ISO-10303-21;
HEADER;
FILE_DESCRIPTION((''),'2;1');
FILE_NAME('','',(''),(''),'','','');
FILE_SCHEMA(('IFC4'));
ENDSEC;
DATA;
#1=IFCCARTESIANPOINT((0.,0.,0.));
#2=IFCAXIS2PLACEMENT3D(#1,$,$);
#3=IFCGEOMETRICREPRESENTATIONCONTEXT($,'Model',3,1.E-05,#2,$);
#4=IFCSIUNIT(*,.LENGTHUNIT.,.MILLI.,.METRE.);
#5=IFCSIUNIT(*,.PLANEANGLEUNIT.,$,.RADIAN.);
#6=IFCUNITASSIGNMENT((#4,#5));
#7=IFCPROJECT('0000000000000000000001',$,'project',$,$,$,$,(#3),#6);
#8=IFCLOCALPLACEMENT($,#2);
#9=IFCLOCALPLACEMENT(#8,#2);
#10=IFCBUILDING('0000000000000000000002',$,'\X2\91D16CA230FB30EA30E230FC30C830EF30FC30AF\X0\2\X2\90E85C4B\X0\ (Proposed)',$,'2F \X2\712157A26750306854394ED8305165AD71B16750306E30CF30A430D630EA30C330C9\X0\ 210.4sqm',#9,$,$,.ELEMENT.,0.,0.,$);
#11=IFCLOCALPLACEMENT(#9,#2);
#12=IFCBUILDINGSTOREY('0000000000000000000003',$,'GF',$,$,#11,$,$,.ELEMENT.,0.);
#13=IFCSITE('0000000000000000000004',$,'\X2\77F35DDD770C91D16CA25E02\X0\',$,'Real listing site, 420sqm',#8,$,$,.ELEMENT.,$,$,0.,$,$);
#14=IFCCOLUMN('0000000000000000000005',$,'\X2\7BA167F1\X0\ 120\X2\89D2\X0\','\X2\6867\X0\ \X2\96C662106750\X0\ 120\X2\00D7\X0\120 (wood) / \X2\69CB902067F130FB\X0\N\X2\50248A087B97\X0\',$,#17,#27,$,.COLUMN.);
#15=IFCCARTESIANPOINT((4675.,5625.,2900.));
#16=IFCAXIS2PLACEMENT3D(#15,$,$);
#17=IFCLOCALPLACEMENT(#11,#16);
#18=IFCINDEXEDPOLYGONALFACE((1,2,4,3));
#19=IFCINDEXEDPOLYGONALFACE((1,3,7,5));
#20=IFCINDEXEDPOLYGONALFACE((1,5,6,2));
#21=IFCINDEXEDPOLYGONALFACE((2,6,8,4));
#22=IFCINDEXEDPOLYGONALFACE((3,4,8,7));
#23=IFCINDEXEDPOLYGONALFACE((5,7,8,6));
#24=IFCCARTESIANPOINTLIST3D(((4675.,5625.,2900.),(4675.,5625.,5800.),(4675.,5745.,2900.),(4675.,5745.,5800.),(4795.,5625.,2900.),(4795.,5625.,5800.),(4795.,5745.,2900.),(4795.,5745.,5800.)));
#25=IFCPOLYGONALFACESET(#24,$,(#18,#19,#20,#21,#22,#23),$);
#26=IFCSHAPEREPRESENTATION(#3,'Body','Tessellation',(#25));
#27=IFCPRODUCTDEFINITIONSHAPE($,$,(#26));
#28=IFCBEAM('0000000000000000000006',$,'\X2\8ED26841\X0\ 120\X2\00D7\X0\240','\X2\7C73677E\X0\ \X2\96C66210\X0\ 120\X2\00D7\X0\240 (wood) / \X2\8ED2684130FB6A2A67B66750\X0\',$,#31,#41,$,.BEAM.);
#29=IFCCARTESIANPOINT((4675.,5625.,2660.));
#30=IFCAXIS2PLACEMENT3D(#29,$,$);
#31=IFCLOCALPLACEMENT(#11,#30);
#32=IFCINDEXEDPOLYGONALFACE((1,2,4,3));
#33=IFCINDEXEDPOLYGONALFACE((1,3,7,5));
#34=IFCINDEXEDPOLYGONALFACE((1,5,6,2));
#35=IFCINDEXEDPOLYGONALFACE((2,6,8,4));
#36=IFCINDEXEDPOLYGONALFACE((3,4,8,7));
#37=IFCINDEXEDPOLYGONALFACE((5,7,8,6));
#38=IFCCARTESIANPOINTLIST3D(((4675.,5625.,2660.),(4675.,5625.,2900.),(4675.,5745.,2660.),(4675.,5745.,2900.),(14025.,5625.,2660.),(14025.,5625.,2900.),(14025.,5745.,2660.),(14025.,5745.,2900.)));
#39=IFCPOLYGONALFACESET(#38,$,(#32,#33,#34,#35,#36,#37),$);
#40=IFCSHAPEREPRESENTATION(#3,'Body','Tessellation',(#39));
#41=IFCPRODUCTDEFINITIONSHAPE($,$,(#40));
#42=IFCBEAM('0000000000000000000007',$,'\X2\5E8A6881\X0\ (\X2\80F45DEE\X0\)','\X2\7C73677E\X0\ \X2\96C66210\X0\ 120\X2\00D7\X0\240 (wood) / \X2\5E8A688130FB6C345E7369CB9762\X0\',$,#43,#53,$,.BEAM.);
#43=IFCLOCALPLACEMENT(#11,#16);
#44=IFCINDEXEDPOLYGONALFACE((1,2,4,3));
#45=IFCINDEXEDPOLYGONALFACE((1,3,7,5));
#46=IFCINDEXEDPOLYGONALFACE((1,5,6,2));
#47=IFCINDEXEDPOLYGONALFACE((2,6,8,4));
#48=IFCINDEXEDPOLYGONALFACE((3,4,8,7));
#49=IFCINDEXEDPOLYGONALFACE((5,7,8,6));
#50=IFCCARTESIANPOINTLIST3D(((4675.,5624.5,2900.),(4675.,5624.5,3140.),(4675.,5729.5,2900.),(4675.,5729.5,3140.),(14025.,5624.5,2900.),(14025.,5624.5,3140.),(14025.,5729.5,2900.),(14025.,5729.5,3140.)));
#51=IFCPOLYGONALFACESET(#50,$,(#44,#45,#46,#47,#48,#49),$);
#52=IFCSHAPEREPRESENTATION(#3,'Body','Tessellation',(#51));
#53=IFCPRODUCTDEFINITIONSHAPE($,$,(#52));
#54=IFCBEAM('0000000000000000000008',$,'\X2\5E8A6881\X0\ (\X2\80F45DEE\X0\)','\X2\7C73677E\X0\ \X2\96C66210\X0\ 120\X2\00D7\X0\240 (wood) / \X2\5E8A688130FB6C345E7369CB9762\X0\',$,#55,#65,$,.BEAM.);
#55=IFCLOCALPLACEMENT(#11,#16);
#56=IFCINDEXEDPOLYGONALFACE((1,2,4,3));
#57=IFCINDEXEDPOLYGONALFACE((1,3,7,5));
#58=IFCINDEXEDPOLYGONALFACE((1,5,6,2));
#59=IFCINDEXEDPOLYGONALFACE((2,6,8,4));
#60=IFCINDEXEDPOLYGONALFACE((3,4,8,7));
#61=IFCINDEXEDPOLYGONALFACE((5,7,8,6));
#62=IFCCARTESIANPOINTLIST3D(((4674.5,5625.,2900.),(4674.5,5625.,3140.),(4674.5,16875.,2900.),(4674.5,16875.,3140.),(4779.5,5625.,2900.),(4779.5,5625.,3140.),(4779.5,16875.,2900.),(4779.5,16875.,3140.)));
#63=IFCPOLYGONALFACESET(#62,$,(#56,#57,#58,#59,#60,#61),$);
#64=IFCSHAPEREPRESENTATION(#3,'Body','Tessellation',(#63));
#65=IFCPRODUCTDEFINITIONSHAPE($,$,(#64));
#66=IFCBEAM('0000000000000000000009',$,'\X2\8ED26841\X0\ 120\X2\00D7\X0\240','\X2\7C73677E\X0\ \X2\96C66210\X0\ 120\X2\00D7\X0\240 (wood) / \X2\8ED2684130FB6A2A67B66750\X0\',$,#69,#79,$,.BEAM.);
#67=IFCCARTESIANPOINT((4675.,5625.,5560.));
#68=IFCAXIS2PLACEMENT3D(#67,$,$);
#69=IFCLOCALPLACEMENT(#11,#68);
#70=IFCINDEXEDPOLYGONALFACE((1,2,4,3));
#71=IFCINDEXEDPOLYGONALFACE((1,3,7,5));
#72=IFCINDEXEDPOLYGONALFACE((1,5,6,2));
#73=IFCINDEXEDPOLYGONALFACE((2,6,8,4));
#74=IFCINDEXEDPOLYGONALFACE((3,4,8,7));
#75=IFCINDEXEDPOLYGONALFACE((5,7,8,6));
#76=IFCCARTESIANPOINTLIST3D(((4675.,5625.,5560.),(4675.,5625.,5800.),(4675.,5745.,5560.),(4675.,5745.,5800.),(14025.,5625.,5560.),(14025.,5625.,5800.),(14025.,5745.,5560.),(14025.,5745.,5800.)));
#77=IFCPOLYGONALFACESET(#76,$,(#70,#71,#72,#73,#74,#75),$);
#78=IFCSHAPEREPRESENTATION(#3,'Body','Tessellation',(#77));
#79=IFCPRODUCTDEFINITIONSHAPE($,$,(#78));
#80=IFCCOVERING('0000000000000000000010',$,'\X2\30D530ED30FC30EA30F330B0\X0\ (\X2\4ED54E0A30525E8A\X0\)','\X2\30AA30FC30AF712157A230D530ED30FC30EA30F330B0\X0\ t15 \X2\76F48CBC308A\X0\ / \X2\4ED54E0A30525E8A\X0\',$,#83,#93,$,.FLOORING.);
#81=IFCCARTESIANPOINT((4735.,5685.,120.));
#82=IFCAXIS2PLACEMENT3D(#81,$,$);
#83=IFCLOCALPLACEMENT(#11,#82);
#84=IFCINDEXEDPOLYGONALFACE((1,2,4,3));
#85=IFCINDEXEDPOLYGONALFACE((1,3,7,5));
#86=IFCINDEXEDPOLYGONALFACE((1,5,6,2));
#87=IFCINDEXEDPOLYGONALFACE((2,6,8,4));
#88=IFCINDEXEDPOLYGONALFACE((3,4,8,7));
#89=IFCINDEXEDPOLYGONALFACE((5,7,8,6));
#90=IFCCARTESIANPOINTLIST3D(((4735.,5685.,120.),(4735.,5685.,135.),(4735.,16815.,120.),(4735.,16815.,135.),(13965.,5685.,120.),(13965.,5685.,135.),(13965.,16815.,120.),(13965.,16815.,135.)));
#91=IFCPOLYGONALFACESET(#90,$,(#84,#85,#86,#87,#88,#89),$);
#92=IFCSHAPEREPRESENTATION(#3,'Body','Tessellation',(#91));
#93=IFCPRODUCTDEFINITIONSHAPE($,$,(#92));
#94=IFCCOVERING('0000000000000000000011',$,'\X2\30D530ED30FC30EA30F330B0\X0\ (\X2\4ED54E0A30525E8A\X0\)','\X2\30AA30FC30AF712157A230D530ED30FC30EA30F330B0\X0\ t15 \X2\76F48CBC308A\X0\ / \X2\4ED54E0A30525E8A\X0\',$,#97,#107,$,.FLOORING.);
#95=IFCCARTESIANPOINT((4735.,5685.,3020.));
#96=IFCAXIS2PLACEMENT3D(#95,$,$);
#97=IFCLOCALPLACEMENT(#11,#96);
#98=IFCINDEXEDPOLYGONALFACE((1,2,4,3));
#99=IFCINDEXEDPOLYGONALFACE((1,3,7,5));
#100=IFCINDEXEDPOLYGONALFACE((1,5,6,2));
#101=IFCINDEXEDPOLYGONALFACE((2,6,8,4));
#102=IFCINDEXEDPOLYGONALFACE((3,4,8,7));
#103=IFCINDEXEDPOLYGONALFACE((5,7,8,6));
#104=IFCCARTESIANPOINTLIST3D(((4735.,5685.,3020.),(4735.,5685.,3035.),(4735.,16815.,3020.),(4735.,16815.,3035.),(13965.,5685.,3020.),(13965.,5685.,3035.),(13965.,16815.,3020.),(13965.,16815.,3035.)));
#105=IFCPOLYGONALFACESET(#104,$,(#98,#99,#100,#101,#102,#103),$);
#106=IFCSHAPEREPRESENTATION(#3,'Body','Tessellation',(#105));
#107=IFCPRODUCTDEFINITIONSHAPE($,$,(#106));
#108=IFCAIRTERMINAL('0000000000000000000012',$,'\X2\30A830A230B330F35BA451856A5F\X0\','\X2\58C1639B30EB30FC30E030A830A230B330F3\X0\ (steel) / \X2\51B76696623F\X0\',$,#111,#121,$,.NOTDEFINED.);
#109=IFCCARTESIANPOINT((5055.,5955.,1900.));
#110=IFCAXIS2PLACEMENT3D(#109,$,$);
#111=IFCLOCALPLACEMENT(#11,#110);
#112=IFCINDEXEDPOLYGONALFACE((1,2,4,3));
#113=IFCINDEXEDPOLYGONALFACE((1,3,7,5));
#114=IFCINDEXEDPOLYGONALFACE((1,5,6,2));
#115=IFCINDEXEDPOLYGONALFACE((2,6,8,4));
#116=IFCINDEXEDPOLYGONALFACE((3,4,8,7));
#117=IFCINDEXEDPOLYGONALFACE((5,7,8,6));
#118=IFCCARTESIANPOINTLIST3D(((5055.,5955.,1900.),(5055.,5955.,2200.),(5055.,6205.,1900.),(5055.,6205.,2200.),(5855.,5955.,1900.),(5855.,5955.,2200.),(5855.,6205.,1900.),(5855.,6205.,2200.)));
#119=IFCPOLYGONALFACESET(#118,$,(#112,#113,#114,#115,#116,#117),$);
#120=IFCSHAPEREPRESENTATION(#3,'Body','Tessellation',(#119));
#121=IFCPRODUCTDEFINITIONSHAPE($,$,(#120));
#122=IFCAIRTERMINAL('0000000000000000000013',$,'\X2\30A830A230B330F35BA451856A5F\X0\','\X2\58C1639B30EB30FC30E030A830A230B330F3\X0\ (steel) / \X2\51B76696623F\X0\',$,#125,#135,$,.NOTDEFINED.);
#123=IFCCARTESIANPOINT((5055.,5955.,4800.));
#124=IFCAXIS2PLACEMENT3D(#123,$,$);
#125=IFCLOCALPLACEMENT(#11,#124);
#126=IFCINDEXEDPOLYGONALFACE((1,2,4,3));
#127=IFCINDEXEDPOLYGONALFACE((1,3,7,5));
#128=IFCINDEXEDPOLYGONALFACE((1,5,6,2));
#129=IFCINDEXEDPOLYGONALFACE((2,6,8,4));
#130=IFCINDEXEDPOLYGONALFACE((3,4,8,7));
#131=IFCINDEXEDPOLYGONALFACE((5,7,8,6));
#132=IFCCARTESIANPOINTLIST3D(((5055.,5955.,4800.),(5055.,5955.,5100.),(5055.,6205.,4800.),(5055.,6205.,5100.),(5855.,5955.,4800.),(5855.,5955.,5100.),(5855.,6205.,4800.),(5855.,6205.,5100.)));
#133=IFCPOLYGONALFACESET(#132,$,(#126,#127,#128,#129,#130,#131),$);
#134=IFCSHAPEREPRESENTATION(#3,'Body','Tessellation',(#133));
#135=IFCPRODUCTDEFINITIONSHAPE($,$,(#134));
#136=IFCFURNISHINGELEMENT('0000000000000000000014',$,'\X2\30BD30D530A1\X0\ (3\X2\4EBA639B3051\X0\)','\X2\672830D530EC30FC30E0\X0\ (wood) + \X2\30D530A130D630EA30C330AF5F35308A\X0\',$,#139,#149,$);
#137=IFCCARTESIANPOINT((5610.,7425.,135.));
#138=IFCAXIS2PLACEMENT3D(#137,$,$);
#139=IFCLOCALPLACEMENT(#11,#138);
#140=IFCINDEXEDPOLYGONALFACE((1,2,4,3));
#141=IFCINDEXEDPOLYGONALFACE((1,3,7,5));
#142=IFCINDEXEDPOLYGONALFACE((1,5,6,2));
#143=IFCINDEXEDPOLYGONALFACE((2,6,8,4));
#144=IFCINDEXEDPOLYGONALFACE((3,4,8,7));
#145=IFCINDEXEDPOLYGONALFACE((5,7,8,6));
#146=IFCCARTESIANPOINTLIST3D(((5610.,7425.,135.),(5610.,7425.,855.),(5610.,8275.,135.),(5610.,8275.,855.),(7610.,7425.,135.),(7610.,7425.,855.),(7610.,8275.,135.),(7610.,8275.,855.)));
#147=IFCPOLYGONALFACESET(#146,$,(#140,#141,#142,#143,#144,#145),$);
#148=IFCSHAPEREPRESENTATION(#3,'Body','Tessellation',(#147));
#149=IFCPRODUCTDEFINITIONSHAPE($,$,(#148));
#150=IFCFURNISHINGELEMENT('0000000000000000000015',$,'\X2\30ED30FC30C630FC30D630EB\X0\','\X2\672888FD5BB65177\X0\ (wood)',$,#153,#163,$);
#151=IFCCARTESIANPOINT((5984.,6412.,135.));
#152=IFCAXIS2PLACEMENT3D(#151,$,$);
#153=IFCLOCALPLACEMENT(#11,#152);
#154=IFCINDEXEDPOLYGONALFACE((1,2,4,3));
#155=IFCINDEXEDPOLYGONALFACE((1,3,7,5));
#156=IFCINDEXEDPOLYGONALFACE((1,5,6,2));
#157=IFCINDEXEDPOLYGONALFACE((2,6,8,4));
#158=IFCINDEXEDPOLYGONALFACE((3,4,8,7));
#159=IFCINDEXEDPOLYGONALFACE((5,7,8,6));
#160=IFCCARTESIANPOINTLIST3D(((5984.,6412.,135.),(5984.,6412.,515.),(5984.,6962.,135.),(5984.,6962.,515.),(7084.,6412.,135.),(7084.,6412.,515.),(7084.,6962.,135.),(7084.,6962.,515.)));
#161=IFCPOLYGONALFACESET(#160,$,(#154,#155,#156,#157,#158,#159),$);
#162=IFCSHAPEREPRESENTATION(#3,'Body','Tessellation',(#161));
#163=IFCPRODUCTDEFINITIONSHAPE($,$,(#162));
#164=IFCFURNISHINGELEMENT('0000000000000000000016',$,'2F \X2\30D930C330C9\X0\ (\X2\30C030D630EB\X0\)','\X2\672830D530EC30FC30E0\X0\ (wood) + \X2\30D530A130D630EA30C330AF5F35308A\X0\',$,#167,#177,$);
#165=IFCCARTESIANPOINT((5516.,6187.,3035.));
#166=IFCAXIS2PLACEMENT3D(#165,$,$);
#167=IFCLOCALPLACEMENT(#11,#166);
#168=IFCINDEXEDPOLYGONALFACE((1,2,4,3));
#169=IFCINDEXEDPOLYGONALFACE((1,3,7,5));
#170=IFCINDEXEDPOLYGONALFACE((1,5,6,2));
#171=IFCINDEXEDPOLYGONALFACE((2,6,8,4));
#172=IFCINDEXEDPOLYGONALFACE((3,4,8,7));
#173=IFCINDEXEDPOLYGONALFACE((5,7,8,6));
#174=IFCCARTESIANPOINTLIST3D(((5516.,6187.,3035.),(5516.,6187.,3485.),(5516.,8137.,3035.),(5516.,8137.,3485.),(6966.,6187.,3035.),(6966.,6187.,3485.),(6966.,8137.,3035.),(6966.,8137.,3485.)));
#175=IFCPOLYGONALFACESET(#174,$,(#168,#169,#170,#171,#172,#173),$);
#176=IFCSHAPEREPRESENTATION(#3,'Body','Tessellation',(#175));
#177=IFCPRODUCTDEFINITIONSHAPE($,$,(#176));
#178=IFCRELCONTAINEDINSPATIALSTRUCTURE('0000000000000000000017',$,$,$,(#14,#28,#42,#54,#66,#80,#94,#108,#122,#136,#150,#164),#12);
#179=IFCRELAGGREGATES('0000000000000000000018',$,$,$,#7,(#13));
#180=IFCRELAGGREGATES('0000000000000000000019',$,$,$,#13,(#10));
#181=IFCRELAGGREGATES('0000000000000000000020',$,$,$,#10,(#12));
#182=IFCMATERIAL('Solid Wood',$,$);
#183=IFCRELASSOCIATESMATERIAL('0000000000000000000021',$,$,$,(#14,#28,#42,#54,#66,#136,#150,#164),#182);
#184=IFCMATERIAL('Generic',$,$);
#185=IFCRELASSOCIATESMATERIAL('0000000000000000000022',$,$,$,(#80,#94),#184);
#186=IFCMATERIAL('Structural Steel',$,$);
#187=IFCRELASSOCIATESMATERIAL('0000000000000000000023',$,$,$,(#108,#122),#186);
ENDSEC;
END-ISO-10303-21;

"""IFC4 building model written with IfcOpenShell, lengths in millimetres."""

from ifc_helpers import new_model, si_unit, frame, frame_2d, origin, place, context, project, spatial, rectangle, extrude, material, element, save


model = new_model("IFC4")

# Units and contexts
model_context = context("Model", 3, precision=1e-05, world=origin())
ifc_project = project(units=[si_unit("LENGTHUNIT", "METRE", prefix="MILLI"), si_unit("PLANEANGLEUNIT", "RADIAN")], contexts=[model_context])

# Site, building, storey
site_placement = place(None, origin())
site = spatial("IfcSite", under=ifc_project, at=site_placement, Name="石川県金沢市", ObjectType="Real listing site, 420sqm", CompositionType="ELEMENT", RefElevation=0.0)
building_placement = place(site_placement, origin())
building = spatial("IfcBuilding", under=site, at=building_placement, Name="金沢・リモートワーク2部屋 (Proposed)", ObjectType="2F 無垢材と吹付け断熱材のハイブリッド 210.4sqm", CompositionType="ELEMENT", ElevationOfRefHeight=0.0, ElevationOfTerrain=0.0)
storey_placement = place(building_placement, origin())
storey = spatial("IfcBuildingStorey", under=building, at=storey_placement, Name="GF", CompositionType="ELEMENT", Elevation=0.0)

# Column
ifc_material_1 = material(Name="Solid Wood")
column_1_placement = place(storey_placement, frame((4675.0, 5625.0, 2900.0)))
element("IfcColumn", 1, at=column_1_placement, inside=storey, material=ifc_material_1, Name="管柱 120角", Description="桧 集成材 120×120 (wood) / 構造柱・N値計算", PredefinedType="COLUMN", context=model_context, shape_type="SweptSolid", body=[
    extrude(rectangle(XDim=120.0, YDim=120.0, at=frame_2d((60.0, 60.0))), frame((4675.0, 5625.0, 2900.0)), (0.0, 0.0, 1.0), 2900.0),
])

# Beams
beam_1_placement = place(storey_placement, frame((4675.0, 5625.0, 2660.0)))
element("IfcBeam", 2, at=beam_1_placement, inside=storey, material=ifc_material_1, Name="軒桁 120×240", Description="米松 集成 120×240 (wood) / 軒桁・横架材", PredefinedType="BEAM", context=model_context, shape_type="SweptSolid", body=[
    extrude(rectangle(XDim=9350.0, YDim=120.0, at=frame_2d((4675.0, 60.0))), frame((4675.0, 5625.0, 2660.0)), (0.0, 0.0, 1.0), 240.0),
])
beam_2_placement = place(storey_placement, frame((4675.0, 5625.0, 2900.0)))
element("IfcBeam", 3, at=beam_2_placement, inside=storey, material=ifc_material_1, Name="床梁 (胴差)", Description="米松 集成 120×240 (wood) / 床梁・水平構面", PredefinedType="BEAM", context=model_context, shape_type="SweptSolid", body=[
    extrude(rectangle(XDim=9350.0, YDim=105.0, at=frame_2d((4675.0, 52.0))), frame((4675.0, 5625.0, 2900.0)), (0.0, 0.0, 1.0), 240.0),
])
beam_3_placement = place(storey_placement, frame((4675.0, 5625.0, 2900.0)))
element("IfcBeam", 4, at=beam_3_placement, inside=storey, material=ifc_material_1, Name="床梁 (胴差)", Description="米松 集成 120×240 (wood) / 床梁・水平構面", PredefinedType="BEAM", context=model_context, shape_type="SweptSolid", body=[
    extrude(rectangle(XDim=105.0, YDim=11250.0, at=frame_2d((52.0, 5625.0))), frame((4675.0, 5625.0, 2900.0)), (0.0, 0.0, 1.0), 240.0),
])
beam_4_placement = place(storey_placement, frame((4675.0, 5625.0, 5560.0)))
element("IfcBeam", 5, at=beam_4_placement, inside=storey, material=ifc_material_1, Name="軒桁 120×240", Description="米松 集成 120×240 (wood) / 軒桁・横架材", PredefinedType="BEAM", context=model_context, shape_type="SweptSolid", body=[
    extrude(rectangle(XDim=9350.0, YDim=120.0, at=frame_2d((4675.0, 60.0))), frame((4675.0, 5625.0, 5560.0)), (0.0, 0.0, 1.0), 240.0),
])

# Coverings
ifc_material_2 = material(Name="Generic")
covering_1_placement = place(storey_placement, frame((4735.0, 5685.0, 120.0)))
element("IfcCovering", 6, at=covering_1_placement, inside=storey, material=ifc_material_2, Name="フローリング (仕上げ床)", Description="オーク無垢フローリング t15 直貼り / 仕上げ床", PredefinedType="FLOORING", context=model_context, shape_type="SweptSolid", body=[
    extrude(rectangle(XDim=9230.0, YDim=11130.0, at=frame_2d((4615.0, 5565.0))), frame((4735.0, 5685.0, 120.0)), (0.0, 0.0, 1.0), 15.0),
])
covering_2_placement = place(storey_placement, frame((4735.0, 5685.0, 3020.0)))
element("IfcCovering", 7, at=covering_2_placement, inside=storey, material=ifc_material_2, Name="フローリング (仕上げ床)", Description="オーク無垢フローリング t15 直貼り / 仕上げ床", PredefinedType="FLOORING", context=model_context, shape_type="SweptSolid", body=[
    extrude(rectangle(XDim=9230.0, YDim=11130.0, at=frame_2d((4615.0, 5565.0))), frame((4735.0, 5685.0, 3020.0)), (0.0, 0.0, 1.0), 15.0),
])

# Air terminals
ifc_material_3 = material(Name="Structural Steel")
air_terminal_1_placement = place(storey_placement, frame((5055.0, 5955.0, 1900.0)))
element("IfcAirTerminal", 8, at=air_terminal_1_placement, inside=storey, material=ifc_material_3, Name="エアコン室内機", Description="壁掛ルームエアコン (steel) / 冷暖房", PredefinedType="NOTDEFINED", context=model_context, shape_type="SweptSolid", body=[
    extrude(rectangle(XDim=800.0, YDim=250.0, at=frame_2d((400.0, 125.0))), frame((5055.0, 5955.0, 1900.0)), (0.0, 0.0, 1.0), 300.0),
])
air_terminal_2_placement = place(storey_placement, frame((5055.0, 5955.0, 4800.0)))
element("IfcAirTerminal", 9, at=air_terminal_2_placement, inside=storey, material=ifc_material_3, Name="エアコン室内機", Description="壁掛ルームエアコン (steel) / 冷暖房", PredefinedType="NOTDEFINED", context=model_context, shape_type="SweptSolid", body=[
    extrude(rectangle(XDim=800.0, YDim=250.0, at=frame_2d((400.0, 125.0))), frame((5055.0, 5955.0, 4800.0)), (0.0, 0.0, 1.0), 300.0),
])

# Furnishing elements
furnishing_1_placement = place(storey_placement, frame((5610.0, 7425.0, 135.0)))
element("IfcFurnishingElement", 10, at=furnishing_1_placement, inside=storey, material=ifc_material_1, Name="ソファ (3人掛け)", Description="木フレーム (wood) + ファブリック張り", context=model_context, shape_type="SweptSolid", body=[
    extrude(rectangle(XDim=2000.0, YDim=850.0, at=frame_2d((1000.0, 425.0))), frame((5610.0, 7425.0, 135.0)), (0.0, 0.0, 1.0), 720.0),
])
furnishing_2_placement = place(storey_placement, frame((5984.0, 6412.0, 135.0)))
element("IfcFurnishingElement", 11, at=furnishing_2_placement, inside=storey, material=ifc_material_1, Name="ローテーブル", Description="木製家具 (wood)", context=model_context, shape_type="SweptSolid", body=[
    extrude(rectangle(XDim=1100.0, YDim=550.0, at=frame_2d((550.0, 275.0))), frame((5984.0, 6412.0, 135.0)), (0.0, 0.0, 1.0), 380.0),
])
furnishing_3_placement = place(storey_placement, frame((5516.0, 6187.0, 3035.0)))
element("IfcFurnishingElement", 12, at=furnishing_3_placement, inside=storey, material=ifc_material_1, Name="2F ベッド (ダブル)", Description="木フレーム (wood) + ファブリック張り", context=model_context, shape_type="SweptSolid", body=[
    extrude(rectangle(XDim=1450.0, YDim=1950.0, at=frame_2d((725.0, 975.0))), frame((5516.0, 6187.0, 3035.0)), (0.0, 0.0, 1.0), 450.0),
])

save(model, "model.ifc")
